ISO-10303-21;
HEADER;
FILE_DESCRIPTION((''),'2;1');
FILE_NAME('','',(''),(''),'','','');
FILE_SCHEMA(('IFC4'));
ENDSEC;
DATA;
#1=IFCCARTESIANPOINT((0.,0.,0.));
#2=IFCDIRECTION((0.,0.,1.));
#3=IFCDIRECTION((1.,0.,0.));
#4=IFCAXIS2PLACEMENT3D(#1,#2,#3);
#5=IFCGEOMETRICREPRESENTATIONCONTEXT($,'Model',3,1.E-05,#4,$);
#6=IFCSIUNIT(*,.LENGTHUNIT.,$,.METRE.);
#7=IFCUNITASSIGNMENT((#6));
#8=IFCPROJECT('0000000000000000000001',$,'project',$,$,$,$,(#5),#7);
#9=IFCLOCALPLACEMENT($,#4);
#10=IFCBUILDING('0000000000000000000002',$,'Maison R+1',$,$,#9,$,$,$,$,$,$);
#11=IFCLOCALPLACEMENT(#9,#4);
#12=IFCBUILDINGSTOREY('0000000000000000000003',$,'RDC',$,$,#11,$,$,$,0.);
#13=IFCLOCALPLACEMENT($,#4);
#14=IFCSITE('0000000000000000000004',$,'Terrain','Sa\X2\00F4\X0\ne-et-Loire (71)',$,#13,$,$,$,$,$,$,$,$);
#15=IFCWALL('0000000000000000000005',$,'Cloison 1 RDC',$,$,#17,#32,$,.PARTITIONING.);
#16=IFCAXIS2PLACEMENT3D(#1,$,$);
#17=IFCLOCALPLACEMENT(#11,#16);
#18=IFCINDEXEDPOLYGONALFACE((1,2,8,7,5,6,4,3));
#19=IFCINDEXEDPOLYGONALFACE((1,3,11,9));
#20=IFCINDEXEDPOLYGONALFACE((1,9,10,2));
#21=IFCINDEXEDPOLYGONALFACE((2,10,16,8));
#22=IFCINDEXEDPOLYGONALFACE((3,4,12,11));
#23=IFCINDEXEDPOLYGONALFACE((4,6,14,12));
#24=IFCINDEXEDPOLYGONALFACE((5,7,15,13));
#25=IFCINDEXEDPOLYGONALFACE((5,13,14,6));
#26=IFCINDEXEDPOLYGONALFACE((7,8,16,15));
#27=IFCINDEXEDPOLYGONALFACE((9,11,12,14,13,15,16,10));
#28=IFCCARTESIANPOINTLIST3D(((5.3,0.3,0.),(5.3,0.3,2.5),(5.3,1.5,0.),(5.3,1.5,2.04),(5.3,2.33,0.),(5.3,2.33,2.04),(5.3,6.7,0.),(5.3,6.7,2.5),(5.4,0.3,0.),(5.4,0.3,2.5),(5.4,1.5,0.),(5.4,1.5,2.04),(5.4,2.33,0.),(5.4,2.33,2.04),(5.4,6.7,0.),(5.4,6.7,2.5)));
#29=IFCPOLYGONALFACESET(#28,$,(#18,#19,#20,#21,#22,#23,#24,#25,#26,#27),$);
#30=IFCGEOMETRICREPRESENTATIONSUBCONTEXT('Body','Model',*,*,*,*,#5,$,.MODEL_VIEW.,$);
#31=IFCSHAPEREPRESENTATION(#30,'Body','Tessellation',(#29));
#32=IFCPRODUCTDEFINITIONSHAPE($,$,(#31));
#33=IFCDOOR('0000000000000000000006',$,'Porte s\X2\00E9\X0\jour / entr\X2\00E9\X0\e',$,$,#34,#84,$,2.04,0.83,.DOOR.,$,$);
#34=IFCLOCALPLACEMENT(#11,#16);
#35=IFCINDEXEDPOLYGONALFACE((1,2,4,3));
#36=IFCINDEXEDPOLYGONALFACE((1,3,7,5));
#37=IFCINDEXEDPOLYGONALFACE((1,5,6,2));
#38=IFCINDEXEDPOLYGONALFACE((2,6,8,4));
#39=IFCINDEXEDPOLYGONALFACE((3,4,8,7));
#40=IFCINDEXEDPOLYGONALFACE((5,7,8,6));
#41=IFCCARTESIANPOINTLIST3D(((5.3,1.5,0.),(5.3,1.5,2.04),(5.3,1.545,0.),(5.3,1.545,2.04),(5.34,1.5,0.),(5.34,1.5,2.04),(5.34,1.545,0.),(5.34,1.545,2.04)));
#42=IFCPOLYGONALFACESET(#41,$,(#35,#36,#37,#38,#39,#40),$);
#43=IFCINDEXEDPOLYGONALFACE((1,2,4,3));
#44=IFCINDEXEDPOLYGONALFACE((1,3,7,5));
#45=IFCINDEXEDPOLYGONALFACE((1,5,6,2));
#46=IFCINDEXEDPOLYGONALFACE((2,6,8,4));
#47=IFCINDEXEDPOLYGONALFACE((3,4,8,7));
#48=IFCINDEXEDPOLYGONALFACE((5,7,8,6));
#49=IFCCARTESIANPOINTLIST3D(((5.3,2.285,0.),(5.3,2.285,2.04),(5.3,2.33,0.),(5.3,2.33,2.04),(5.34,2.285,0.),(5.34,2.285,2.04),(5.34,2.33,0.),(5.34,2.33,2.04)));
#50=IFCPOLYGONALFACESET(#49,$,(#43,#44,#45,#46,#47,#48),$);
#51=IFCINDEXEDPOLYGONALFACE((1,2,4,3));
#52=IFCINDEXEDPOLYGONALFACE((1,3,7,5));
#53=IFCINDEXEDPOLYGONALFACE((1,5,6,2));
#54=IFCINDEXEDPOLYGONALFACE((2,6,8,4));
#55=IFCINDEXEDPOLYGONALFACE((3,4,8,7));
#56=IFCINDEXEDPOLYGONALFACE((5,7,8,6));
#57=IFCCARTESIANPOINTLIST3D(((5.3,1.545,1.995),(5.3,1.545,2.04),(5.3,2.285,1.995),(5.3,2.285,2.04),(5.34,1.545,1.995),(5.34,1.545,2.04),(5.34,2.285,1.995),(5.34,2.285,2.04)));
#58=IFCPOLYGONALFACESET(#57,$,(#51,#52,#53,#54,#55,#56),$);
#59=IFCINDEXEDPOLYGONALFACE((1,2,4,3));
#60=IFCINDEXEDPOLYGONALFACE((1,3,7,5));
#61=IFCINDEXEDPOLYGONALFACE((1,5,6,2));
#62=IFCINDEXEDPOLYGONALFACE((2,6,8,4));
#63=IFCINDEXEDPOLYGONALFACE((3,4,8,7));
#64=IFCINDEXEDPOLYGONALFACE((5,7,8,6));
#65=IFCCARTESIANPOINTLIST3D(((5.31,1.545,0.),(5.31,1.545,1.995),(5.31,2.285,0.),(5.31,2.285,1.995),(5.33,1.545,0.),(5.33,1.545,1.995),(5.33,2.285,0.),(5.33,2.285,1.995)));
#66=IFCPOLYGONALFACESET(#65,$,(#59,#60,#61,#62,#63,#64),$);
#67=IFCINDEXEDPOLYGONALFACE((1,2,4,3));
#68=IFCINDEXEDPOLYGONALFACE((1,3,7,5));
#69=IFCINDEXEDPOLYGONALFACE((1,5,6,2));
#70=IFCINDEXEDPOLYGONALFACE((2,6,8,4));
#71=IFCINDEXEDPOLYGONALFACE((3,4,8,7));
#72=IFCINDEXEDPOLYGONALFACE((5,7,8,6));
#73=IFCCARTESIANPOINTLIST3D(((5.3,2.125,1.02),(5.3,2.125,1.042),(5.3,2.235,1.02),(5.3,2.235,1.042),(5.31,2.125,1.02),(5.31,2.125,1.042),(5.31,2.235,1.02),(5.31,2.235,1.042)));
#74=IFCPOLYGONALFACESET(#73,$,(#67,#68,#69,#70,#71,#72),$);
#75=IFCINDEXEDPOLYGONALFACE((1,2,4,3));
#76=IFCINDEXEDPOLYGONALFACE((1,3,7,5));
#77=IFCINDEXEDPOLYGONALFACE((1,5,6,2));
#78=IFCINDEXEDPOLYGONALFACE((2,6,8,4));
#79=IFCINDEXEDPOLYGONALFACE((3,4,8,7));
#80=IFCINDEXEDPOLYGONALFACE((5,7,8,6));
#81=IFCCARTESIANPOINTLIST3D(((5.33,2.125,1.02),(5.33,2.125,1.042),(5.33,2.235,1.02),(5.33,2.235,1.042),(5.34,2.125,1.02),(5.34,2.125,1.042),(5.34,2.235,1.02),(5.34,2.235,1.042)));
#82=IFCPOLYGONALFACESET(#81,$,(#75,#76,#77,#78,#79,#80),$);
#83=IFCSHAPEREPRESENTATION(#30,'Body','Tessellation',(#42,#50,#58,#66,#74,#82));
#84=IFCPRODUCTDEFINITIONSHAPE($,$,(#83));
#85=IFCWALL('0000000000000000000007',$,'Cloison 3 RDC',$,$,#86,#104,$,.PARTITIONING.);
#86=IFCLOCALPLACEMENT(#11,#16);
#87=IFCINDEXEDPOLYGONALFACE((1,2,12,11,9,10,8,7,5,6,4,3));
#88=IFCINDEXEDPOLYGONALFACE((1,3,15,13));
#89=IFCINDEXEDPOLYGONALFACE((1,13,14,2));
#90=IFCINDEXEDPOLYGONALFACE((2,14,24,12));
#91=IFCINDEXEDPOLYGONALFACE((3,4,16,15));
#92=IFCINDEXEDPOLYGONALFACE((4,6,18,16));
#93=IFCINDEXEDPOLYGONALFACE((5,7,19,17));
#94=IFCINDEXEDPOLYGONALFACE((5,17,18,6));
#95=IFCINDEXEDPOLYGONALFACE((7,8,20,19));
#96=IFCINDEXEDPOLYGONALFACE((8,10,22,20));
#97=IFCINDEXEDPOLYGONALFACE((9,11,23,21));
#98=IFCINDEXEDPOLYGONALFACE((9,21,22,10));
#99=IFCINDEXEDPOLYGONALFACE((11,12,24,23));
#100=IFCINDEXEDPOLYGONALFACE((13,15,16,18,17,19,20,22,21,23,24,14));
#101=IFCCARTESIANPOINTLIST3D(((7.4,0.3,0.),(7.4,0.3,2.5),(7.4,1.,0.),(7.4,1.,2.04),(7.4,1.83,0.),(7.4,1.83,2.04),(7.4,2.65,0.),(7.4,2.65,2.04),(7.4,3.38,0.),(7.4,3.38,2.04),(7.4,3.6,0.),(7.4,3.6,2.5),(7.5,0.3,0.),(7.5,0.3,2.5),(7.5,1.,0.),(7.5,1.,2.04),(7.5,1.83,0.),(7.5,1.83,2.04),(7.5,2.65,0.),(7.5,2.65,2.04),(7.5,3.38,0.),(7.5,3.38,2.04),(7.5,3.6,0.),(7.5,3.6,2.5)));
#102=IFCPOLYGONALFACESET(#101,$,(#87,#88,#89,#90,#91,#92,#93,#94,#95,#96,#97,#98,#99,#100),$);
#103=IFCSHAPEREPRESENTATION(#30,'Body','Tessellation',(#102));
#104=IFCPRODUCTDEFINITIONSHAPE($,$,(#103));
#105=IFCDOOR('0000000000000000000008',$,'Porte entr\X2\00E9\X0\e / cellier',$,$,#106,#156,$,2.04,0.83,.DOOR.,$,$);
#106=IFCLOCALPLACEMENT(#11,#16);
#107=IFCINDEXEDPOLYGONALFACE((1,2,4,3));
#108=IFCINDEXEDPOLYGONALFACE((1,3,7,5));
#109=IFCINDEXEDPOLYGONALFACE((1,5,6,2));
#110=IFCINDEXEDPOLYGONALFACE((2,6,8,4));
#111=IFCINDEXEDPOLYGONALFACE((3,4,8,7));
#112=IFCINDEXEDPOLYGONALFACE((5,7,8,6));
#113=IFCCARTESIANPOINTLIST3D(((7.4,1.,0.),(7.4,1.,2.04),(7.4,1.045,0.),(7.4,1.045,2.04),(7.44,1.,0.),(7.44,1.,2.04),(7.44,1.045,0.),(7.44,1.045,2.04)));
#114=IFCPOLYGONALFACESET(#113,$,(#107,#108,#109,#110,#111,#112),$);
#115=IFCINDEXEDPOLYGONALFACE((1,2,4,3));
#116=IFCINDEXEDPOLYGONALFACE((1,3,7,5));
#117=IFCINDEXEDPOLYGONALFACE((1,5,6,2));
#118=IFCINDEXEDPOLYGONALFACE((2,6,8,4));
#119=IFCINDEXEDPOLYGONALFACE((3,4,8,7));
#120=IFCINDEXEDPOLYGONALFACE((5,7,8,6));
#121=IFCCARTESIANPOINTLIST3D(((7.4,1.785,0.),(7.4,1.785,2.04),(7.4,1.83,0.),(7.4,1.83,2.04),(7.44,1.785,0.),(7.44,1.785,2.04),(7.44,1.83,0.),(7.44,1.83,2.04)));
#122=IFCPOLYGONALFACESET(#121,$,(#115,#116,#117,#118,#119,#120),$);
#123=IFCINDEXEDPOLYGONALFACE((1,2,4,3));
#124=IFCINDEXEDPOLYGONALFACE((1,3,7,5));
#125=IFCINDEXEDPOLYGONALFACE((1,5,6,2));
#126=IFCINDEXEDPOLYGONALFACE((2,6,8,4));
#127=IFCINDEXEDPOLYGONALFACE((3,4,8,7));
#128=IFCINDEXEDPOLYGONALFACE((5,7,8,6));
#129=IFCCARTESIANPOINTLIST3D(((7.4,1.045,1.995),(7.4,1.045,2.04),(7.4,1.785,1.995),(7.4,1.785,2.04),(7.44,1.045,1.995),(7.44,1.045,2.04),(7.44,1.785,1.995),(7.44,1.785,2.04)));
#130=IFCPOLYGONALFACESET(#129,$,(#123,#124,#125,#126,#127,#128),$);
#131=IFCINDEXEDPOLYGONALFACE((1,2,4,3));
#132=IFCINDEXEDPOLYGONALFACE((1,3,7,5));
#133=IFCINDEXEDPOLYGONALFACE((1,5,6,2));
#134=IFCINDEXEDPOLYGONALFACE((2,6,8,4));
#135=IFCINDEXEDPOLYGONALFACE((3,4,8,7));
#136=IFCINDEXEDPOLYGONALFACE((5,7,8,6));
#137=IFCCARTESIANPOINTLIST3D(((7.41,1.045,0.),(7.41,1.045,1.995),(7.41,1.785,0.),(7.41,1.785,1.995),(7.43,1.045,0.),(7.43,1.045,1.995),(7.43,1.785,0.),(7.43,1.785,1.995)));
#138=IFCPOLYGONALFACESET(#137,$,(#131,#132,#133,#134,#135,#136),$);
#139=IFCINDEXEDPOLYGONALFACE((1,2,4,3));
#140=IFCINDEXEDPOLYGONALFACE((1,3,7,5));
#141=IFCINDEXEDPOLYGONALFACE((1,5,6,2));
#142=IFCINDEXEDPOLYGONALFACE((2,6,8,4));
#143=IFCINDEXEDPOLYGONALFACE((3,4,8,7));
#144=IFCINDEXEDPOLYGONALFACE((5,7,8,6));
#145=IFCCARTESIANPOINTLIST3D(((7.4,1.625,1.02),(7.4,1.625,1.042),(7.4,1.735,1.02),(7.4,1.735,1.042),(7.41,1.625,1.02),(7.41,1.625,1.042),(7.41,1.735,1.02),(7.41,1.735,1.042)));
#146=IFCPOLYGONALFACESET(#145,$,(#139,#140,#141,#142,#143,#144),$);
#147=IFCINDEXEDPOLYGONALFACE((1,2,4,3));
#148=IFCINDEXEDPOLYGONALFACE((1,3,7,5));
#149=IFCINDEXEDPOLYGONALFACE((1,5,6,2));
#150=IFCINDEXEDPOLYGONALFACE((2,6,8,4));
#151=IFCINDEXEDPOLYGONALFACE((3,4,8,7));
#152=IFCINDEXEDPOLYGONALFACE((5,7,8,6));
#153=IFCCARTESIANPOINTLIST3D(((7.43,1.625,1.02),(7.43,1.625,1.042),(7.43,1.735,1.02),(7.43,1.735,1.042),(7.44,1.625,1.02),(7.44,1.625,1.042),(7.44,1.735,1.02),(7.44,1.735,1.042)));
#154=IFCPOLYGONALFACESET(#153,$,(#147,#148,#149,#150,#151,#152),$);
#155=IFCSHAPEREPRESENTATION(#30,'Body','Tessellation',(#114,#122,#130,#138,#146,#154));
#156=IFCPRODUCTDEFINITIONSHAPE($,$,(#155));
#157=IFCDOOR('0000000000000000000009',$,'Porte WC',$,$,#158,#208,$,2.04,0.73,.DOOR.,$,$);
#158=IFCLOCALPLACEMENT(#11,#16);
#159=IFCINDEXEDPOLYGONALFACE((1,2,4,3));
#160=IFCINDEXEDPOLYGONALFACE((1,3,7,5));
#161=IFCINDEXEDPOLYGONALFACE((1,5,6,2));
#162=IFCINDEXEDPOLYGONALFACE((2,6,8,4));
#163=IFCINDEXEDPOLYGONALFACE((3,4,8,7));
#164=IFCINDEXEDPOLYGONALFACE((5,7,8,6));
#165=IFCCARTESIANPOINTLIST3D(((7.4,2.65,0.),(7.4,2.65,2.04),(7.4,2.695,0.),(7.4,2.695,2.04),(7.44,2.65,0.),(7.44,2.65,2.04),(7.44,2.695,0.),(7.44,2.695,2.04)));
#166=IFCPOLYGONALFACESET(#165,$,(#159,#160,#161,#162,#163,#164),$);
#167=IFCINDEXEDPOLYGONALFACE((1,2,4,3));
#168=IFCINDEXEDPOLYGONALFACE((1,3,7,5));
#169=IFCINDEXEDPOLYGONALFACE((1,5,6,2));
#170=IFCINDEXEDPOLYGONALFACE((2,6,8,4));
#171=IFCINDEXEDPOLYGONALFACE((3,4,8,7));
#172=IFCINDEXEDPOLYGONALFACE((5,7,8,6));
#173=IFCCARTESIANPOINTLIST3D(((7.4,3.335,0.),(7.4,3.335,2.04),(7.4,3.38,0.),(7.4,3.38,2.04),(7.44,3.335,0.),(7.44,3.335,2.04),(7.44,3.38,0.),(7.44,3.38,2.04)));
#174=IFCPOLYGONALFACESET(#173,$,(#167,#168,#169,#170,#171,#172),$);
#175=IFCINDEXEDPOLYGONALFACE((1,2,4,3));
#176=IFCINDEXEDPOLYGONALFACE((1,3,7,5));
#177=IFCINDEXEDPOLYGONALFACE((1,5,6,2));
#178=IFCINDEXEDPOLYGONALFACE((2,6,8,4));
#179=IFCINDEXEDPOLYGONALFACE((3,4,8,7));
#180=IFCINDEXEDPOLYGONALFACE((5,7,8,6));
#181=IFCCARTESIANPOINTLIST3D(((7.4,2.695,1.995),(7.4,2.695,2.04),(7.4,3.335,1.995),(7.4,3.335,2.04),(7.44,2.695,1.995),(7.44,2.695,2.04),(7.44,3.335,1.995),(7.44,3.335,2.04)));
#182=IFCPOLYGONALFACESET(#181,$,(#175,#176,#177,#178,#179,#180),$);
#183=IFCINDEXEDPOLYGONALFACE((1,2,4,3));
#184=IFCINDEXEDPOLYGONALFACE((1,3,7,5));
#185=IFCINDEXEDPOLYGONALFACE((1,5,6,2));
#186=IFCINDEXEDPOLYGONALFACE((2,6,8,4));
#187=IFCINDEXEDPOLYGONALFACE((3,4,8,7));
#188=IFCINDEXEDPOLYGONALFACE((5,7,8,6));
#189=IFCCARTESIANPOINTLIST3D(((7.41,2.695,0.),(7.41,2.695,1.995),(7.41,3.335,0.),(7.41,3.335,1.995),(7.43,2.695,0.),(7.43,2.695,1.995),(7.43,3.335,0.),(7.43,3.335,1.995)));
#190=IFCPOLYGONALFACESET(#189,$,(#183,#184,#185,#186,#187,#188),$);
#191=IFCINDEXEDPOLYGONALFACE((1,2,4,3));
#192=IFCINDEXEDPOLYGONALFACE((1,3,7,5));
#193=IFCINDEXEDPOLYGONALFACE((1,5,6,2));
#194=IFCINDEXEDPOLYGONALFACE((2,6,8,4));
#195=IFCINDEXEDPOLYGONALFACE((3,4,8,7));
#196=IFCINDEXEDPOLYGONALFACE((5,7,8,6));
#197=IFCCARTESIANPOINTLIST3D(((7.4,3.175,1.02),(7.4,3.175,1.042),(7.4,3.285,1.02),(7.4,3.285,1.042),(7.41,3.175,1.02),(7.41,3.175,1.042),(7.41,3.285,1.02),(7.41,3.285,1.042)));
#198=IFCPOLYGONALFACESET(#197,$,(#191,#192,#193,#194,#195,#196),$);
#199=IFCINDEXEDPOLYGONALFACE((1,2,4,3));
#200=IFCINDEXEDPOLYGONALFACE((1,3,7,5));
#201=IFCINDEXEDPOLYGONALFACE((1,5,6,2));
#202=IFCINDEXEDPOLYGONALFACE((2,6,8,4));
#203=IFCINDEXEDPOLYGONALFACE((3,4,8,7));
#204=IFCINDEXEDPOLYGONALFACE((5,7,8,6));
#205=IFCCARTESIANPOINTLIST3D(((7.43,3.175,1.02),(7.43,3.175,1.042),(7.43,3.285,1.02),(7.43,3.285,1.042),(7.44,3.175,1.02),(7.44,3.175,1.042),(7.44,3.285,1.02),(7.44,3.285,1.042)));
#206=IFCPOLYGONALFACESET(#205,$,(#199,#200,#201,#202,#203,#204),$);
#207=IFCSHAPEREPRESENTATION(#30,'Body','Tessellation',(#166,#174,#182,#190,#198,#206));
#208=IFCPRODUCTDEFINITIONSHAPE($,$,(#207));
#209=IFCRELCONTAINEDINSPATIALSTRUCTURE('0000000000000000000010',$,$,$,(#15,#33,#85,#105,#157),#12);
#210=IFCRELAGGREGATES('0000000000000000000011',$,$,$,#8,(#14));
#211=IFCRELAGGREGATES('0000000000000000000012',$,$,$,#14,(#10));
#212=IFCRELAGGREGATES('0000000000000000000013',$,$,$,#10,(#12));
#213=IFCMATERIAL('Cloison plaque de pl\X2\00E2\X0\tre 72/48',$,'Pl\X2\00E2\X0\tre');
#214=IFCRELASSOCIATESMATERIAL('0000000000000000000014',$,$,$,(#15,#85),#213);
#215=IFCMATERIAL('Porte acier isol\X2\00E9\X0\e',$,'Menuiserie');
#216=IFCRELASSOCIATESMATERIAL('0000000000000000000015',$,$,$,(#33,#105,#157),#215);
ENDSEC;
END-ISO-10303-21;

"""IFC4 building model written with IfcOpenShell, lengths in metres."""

from ifc_helpers import new_model, si_unit, frame, frame_2d, origin_with_axes, place, context, subcontext, project, spatial, rectangle, extrude, material, element, fill, save


model = new_model("IFC4")

# Units and contexts
model_context = context("Model", 3, precision=1e-05, world=origin_with_axes())
body_context = subcontext(model_context, "Body", "Model", "MODEL_VIEW")
ifc_project = project(units=[si_unit("LENGTHUNIT", "METRE")], contexts=[model_context])

# Site, building, storey
site_placement = place(None, origin_with_axes())
site = spatial("IfcSite", under=ifc_project, at=site_placement, Name="Terrain", Description="Saône-et-Loire (71)")
building_placement = place(None, origin_with_axes())
building = spatial("IfcBuilding", under=site, at=building_placement, Name="Maison R+1")
storey_placement = place(building_placement, origin_with_axes())
storey = spatial("IfcBuildingStorey", under=building, at=storey_placement, Name="RDC", Elevation=0.0)

# Wall, opening, door
ifc_material_1 = material(Name="Cloison plaque de plâtre 72/48", Category="Plâtre")
wall_1_placement = place(storey_placement, frame((5.3, 0.3, 0.0), z_axis=(0.0, 0.0, 1.0), x_axis=(1.0, 0.0, 0.0)))
wall_1 = element("IfcWall", 1, at=wall_1_placement, inside=storey, material=ifc_material_1, Name="Cloison 1 RDC", PredefinedType="PARTITIONING", context=body_context, shape_type="SweptSolid", body=[
    extrude(rectangle(XDim=0.1, YDim=6.4, at=frame_2d((0.05, 3.2))), origin_with_axes(), (0.0, 0.0, 1.0), 2.5),
])
opening_1_placement = place(storey_placement, frame((5.25, 1.5, 0.0), z_axis=(0.0, 0.0, 1.0), x_axis=(1.0, 0.0, 0.0)))
opening_1 = element("IfcOpeningElement", 2, at=opening_1_placement, cuts=wall_1, context=body_context, shape_type="SweptSolid", body=[
    extrude(rectangle(XDim=0.2, YDim=0.83, at=frame_2d((0.1, 0.415))), origin_with_axes(), (0.0, 0.0, 1.0), 2.04),
])
ifc_material_2 = material(Name="Porte acier isolée", Category="Menuiserie")
door_1_placement = place(storey_placement, frame((5.3, 1.5, 0.0), z_axis=(0.0, 0.0, 1.0), x_axis=(1.0, 0.0, 0.0)))
door_1 = element("IfcDoor", 3, at=door_1_placement, inside=storey, material=ifc_material_2, Name="Porte séjour / entrée", OverallHeight=2.04, OverallWidth=0.83, PredefinedType="DOOR", context=body_context, shape_type="SweptSolid", body=[
    extrude(rectangle(XDim=0.04, YDim=0.045, at=frame_2d((0.02, 0.0225))), origin_with_axes(), (0.0, 0.0, 1.0), 2.04),
    extrude(rectangle(XDim=0.04, YDim=0.045, at=frame_2d((0.02, 0.0225))), frame((0.0, 0.785, 0.0), z_axis=(0.0, 0.0, 1.0), x_axis=(1.0, 0.0, 0.0)), (0.0, 0.0, 1.0), 2.04),
    extrude(rectangle(XDim=0.04, YDim=0.74, at=frame_2d((0.02, 0.37))), frame((0.0, 0.045, 1.995), z_axis=(0.0, 0.0, 1.0), x_axis=(1.0, 0.0, 0.0)), (0.0, 0.0, 1.0), 0.045),
    extrude(rectangle(XDim=0.02, YDim=0.74, at=frame_2d((0.01, 0.37))), frame((0.01, 0.045, 0.0), z_axis=(0.0, 0.0, 1.0), x_axis=(1.0, 0.0, 0.0)), (0.0, 0.0, 1.0), 1.995),
    extrude(rectangle(XDim=0.01, YDim=0.11, at=frame_2d((0.005, 0.055))), frame((0.0, 0.625, 1.02), z_axis=(0.0, 0.0, 1.0), x_axis=(1.0, 0.0, 0.0)), (0.0, 0.0, 1.0), 0.022),
    extrude(rectangle(XDim=0.01, YDim=0.11, at=frame_2d((0.005, 0.055))), frame((0.03, 0.625, 1.02), z_axis=(0.0, 0.0, 1.0), x_axis=(1.0, 0.0, 0.0)), (0.0, 0.0, 1.0), 0.022),
])
fill(opening_1, door_1)

# Wall, openings, doors
wall_2_placement = place(storey_placement, frame((7.4, 0.3, 0.0), z_axis=(0.0, 0.0, 1.0), x_axis=(1.0, 0.0, 0.0)))
wall_2 = element("IfcWall", 4, at=wall_2_placement, inside=storey, material=ifc_material_1, Name="Cloison 3 RDC", PredefinedType="PARTITIONING", context=body_context, shape_type="SweptSolid", body=[
    extrude(rectangle(XDim=0.1, YDim=3.3, at=frame_2d((0.05, 1.65))), origin_with_axes(), (0.0, 0.0, 1.0), 2.5),
])
opening_2_placement = place(storey_placement, frame((7.35, 1.0, 0.0), z_axis=(0.0, 0.0, 1.0), x_axis=(1.0, 0.0, 0.0)))
opening_2 = element("IfcOpeningElement", 5, at=opening_2_placement, cuts=wall_2, context=body_context, shape_type="SweptSolid", body=[
    extrude(rectangle(XDim=0.2, YDim=0.83, at=frame_2d((0.1, 0.415))), origin_with_axes(), (0.0, 0.0, 1.0), 2.04),
])
opening_3_placement = place(storey_placement, frame((7.35, 2.65, 0.0), z_axis=(0.0, 0.0, 1.0), x_axis=(1.0, 0.0, 0.0)))
opening_3 = element("IfcOpeningElement", 6, at=opening_3_placement, cuts=wall_2, context=body_context, shape_type="SweptSolid", body=[
    extrude(rectangle(XDim=0.2, YDim=0.73, at=frame_2d((0.1, 0.365))), origin_with_axes(), (0.0, 0.0, 1.0), 2.04),
])
door_2_placement = place(storey_placement, frame((7.4, 1.0, 0.0), z_axis=(0.0, 0.0, 1.0), x_axis=(1.0, 0.0, 0.0)))
door_2 = element("IfcDoor", 7, at=door_2_placement, inside=storey, material=ifc_material_2, Name="Porte entrée / cellier", OverallHeight=2.04, OverallWidth=0.83, PredefinedType="DOOR", context=body_context, shape_type="SweptSolid", body=[
    extrude(rectangle(XDim=0.04, YDim=0.045, at=frame_2d((0.02, 0.0225))), origin_with_axes(), (0.0, 0.0, 1.0), 2.04),
    extrude(rectangle(XDim=0.04, YDim=0.045, at=frame_2d((0.02, 0.0225))), frame((0.0, 0.785, 0.0), z_axis=(0.0, 0.0, 1.0), x_axis=(1.0, 0.0, 0.0)), (0.0, 0.0, 1.0), 2.04),
    extrude(rectangle(XDim=0.04, YDim=0.74, at=frame_2d((0.02, 0.37))), frame((0.0, 0.045, 1.995), z_axis=(0.0, 0.0, 1.0), x_axis=(1.0, 0.0, 0.0)), (0.0, 0.0, 1.0), 0.045),
    extrude(rectangle(XDim=0.02, YDim=0.74, at=frame_2d((0.01, 0.37))), frame((0.01, 0.045, 0.0), z_axis=(0.0, 0.0, 1.0), x_axis=(1.0, 0.0, 0.0)), (0.0, 0.0, 1.0), 1.995),
    extrude(rectangle(XDim=0.01, YDim=0.11, at=frame_2d((0.005, 0.055))), frame((0.0, 0.625, 1.02), z_axis=(0.0, 0.0, 1.0), x_axis=(1.0, 0.0, 0.0)), (0.0, 0.0, 1.0), 0.022),
    extrude(rectangle(XDim=0.01, YDim=0.11, at=frame_2d((0.005, 0.055))), frame((0.03, 0.625, 1.02), z_axis=(0.0, 0.0, 1.0), x_axis=(1.0, 0.0, 0.0)), (0.0, 0.0, 1.0), 0.022),
])
fill(opening_2, door_2)
door_3_placement = place(storey_placement, frame((7.4, 2.65, 0.0), z_axis=(0.0, 0.0, 1.0), x_axis=(1.0, 0.0, 0.0)))
door_3 = element("IfcDoor", 8, at=door_3_placement, inside=storey, material=ifc_material_2, Name="Porte WC", OverallHeight=2.04, OverallWidth=0.73, PredefinedType="DOOR", context=body_context, shape_type="SweptSolid", body=[
    extrude(rectangle(XDim=0.04, YDim=0.045, at=frame_2d((0.02, 0.0225))), origin_with_axes(), (0.0, 0.0, 1.0), 2.04),
    extrude(rectangle(XDim=0.04, YDim=0.045, at=frame_2d((0.02, 0.0225))), frame((0.0, 0.685, 0.0), z_axis=(0.0, 0.0, 1.0), x_axis=(1.0, 0.0, 0.0)), (0.0, 0.0, 1.0), 2.04),
    extrude(rectangle(XDim=0.04, YDim=0.64, at=frame_2d((0.02, 0.32))), frame((0.0, 0.045, 1.995), z_axis=(0.0, 0.0, 1.0), x_axis=(1.0, 0.0, 0.0)), (0.0, 0.0, 1.0), 0.045),
    extrude(rectangle(XDim=0.02, YDim=0.64, at=frame_2d((0.01, 0.32))), frame((0.01, 0.045, 0.0), z_axis=(0.0, 0.0, 1.0), x_axis=(1.0, 0.0, 0.0)), (0.0, 0.0, 1.0), 1.995),
    extrude(rectangle(XDim=0.01, YDim=0.11, at=frame_2d((0.005, 0.055))), frame((0.0, 0.525, 1.02), z_axis=(0.0, 0.0, 1.0), x_axis=(1.0, 0.0, 0.0)), (0.0, 0.0, 1.0), 0.022),
    extrude(rectangle(XDim=0.01, YDim=0.11, at=frame_2d((0.005, 0.055))), frame((0.03, 0.525, 1.02), z_axis=(0.0, 0.0, 1.0), x_axis=(1.0, 0.0, 0.0)), (0.0, 0.0, 1.0), 0.022),
])
fill(opening_3, door_3)

save(model, "model.ifc")
